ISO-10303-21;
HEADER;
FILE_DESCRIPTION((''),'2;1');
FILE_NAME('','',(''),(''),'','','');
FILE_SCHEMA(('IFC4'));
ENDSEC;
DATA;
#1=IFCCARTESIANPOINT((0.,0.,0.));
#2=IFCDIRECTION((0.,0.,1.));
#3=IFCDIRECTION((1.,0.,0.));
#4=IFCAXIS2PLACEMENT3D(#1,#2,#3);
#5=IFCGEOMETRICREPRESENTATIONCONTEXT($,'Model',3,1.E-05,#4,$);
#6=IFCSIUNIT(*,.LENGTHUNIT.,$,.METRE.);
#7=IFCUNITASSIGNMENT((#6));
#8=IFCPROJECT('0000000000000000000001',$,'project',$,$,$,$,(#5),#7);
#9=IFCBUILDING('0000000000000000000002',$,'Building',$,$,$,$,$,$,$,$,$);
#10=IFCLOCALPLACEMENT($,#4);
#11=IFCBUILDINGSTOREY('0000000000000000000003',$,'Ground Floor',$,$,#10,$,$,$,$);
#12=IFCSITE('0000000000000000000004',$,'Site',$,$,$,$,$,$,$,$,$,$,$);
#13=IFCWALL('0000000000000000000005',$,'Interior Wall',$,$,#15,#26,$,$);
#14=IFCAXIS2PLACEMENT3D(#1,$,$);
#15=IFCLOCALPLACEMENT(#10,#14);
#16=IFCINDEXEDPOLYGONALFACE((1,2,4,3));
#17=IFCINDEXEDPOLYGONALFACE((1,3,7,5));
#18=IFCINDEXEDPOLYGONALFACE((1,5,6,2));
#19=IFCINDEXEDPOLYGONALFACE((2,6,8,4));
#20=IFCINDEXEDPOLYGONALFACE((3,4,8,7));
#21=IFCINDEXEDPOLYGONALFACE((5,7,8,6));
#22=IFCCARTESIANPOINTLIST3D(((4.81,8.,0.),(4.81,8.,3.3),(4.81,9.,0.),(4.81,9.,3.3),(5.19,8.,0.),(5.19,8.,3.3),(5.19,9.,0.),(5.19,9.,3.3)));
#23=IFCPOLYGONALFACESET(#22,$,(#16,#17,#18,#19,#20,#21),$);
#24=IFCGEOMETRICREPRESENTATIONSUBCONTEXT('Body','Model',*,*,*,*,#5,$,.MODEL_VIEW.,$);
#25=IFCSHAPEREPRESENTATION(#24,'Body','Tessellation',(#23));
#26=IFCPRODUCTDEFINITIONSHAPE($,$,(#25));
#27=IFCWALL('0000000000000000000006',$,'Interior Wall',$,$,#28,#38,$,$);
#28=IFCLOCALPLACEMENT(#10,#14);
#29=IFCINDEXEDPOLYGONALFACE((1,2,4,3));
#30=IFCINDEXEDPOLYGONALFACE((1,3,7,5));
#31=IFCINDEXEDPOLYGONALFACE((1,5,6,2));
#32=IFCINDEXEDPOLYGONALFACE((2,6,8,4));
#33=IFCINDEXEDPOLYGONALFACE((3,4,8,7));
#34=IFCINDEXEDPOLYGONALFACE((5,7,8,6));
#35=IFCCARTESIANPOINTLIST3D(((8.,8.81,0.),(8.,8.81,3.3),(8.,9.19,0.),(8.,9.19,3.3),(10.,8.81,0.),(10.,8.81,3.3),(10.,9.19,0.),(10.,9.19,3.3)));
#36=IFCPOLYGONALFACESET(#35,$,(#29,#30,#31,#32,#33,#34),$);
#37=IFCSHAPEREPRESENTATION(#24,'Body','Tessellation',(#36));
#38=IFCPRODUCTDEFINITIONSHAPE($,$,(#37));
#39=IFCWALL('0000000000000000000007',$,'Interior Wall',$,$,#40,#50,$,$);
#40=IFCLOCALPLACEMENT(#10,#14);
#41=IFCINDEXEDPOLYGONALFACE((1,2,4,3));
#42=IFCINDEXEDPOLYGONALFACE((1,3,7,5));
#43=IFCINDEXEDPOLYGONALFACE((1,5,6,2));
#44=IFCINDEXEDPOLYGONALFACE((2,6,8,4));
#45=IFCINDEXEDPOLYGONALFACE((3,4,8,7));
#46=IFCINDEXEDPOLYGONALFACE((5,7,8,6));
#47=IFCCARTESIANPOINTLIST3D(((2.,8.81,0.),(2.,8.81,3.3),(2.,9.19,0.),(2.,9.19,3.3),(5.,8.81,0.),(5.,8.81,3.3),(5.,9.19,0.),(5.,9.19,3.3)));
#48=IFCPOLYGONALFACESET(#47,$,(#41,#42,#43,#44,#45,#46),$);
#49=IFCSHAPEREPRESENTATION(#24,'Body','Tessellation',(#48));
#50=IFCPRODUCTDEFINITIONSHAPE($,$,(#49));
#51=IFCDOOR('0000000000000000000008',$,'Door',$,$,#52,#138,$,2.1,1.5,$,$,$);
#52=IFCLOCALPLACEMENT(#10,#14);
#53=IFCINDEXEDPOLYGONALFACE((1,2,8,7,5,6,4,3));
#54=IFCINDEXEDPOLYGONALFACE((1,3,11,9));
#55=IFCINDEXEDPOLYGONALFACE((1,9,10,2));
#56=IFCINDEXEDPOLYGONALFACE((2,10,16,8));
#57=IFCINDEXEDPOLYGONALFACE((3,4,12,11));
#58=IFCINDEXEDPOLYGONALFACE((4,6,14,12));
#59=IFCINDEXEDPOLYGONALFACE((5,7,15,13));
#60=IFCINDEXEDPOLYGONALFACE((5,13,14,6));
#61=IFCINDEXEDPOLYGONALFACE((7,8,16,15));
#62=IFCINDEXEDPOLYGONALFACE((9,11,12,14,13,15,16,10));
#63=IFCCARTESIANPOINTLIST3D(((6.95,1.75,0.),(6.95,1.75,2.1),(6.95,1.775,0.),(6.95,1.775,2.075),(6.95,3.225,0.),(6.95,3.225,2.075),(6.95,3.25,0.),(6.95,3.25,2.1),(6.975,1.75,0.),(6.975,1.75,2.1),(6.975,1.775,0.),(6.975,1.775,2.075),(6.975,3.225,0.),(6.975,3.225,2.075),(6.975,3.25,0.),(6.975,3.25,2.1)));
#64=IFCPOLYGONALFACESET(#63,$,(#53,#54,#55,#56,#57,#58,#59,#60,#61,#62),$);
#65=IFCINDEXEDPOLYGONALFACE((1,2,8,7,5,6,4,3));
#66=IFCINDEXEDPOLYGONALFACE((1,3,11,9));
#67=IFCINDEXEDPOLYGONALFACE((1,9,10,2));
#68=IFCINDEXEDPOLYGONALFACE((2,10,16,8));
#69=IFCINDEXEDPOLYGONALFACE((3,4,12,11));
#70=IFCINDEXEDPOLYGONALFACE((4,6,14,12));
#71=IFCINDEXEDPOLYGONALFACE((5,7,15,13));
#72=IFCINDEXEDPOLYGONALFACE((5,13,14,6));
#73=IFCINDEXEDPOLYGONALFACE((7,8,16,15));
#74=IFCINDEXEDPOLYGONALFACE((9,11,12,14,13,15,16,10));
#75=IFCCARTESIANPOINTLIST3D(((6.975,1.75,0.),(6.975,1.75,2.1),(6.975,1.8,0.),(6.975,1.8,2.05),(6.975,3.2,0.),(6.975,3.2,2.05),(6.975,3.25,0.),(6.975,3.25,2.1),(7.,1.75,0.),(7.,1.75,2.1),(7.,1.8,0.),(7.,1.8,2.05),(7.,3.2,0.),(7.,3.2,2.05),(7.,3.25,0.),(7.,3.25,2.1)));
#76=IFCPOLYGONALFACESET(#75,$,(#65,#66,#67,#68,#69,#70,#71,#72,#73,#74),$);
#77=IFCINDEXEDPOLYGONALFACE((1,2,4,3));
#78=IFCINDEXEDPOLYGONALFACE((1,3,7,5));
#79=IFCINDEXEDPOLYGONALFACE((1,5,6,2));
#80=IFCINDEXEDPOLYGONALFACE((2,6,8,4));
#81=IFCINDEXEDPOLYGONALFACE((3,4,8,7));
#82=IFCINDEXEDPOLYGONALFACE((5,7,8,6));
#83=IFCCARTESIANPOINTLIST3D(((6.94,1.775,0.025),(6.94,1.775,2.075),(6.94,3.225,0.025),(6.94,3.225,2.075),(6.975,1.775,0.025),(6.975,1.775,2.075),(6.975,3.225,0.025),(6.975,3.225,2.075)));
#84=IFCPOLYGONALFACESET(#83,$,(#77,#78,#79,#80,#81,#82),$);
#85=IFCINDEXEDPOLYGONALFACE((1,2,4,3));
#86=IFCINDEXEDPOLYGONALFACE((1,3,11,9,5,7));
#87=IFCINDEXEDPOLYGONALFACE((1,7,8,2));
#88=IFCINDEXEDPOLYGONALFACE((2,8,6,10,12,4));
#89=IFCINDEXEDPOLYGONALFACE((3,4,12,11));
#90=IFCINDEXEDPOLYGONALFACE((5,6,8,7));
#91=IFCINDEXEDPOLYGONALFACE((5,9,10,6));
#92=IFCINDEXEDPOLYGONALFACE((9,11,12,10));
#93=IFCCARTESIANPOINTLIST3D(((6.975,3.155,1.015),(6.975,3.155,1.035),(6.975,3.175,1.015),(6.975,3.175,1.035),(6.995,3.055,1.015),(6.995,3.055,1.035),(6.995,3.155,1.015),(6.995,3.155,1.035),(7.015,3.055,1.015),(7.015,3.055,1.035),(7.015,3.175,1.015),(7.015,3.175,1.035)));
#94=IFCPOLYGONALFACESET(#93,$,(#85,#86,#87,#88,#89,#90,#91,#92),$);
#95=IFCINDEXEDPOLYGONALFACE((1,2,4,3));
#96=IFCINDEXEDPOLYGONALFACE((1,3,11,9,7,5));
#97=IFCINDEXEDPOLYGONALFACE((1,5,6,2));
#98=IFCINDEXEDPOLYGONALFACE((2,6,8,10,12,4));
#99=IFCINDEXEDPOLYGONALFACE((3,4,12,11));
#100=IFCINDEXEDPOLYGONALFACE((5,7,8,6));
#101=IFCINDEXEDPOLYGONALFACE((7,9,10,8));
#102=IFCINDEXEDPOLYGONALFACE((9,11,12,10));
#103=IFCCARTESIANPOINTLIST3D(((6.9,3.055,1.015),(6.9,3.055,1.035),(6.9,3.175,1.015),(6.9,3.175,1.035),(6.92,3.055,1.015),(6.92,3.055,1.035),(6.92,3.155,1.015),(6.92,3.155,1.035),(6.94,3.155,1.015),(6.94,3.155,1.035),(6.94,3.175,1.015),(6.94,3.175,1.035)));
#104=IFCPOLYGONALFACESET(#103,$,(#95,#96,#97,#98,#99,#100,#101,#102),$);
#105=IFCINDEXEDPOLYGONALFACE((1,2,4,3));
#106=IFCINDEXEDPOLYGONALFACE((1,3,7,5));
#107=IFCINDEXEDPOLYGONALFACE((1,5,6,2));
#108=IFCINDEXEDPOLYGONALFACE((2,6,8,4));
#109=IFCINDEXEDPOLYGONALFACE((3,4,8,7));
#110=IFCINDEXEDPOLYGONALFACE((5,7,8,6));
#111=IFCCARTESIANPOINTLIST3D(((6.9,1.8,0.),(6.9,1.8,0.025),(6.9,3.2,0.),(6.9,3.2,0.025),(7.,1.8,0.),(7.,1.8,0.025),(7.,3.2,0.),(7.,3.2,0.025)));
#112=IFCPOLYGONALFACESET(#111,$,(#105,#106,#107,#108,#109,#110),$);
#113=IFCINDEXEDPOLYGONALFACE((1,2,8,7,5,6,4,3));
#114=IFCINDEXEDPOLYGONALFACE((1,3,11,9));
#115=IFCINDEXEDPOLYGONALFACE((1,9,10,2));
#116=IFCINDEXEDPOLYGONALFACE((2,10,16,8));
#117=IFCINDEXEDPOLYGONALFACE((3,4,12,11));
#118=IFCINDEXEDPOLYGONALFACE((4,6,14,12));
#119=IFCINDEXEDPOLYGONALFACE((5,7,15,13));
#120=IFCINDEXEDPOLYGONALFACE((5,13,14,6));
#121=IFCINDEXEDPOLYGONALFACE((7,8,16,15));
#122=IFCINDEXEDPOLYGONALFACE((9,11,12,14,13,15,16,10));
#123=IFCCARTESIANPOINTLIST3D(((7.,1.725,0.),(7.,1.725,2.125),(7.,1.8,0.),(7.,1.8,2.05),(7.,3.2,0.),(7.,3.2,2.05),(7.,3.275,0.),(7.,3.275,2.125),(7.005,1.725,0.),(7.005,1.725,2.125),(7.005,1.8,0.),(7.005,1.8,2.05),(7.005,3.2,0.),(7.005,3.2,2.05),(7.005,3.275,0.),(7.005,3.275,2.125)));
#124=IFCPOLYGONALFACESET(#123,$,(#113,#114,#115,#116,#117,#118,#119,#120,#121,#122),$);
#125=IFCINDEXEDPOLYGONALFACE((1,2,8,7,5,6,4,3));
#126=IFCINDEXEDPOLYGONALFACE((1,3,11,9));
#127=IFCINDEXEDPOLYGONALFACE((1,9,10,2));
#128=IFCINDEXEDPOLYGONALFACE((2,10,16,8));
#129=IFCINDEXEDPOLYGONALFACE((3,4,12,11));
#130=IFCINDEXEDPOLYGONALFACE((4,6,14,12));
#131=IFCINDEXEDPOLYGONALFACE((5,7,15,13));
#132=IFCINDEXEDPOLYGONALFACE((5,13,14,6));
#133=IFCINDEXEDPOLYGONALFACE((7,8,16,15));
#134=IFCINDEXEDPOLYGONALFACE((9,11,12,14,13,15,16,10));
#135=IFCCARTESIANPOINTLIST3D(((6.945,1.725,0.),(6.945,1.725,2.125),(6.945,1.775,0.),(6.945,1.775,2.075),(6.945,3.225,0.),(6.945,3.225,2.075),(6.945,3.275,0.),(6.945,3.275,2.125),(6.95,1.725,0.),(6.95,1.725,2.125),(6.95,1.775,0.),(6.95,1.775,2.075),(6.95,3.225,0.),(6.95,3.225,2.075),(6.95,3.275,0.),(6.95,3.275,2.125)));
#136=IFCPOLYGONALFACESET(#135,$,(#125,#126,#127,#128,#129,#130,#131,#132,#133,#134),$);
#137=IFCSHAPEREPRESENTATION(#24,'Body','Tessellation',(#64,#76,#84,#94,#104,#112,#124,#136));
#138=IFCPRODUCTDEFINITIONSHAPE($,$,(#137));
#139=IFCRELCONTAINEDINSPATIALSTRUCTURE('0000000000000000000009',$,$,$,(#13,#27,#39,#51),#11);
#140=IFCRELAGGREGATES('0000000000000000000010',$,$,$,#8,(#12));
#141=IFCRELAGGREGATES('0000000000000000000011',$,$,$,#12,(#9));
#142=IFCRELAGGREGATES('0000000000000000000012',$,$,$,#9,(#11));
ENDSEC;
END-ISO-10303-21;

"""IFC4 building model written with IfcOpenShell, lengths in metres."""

from ifc_helpers import new_model, si_unit, frame, origin_with_axes, place, context, subcontext, project, spatial, line, indexed_curve, outline, extrude, element, save


model = new_model("IFC4")

# Units and contexts
model_context = context("Model", 3, precision=1e-05, world=origin_with_axes())
body_context = subcontext(model_context, "Body", "Model", "MODEL_VIEW")
ifc_project = project(units=[si_unit("LENGTHUNIT", "METRE")], contexts=[model_context])

# Site, building, storey
site = spatial("IfcSite", under=ifc_project, Name="Site")
building = spatial("IfcBuilding", under=site, Name="Building")
storey_placement = place(None, origin_with_axes())
storey = spatial("IfcBuildingStorey", under=building, at=storey_placement, Name="Ground Floor")

# Walls
wall_1_placement = place(storey_placement, frame((5.0, 9.0, 0.0), z_axis=(0.0, 0.0, 1.0), x_axis=(0.0, -1.0, 0.0)))
element("IfcWall", 1, at=wall_1_placement, inside=storey, Name="Interior Wall", context=body_context, shape_type="SweptSolid", body=[
    extrude(outline(indexed_curve([(0.0, 0.0), (0.0, 0.38), (1.0, 0.38), (1.0, 0.0), (0.0, 0.0)], self_intersect=False)), frame((0.0, -0.19, 0.0), z_axis=(0.0, 0.0, 1.0), x_axis=(1.0, 0.0, 0.0)), (0.0, 0.0, 1.0), 3.3),
])
wall_2_placement = place(storey_placement, frame((10.0, 9.0, 0.0), z_axis=(0.0, 0.0, 1.0), x_axis=(-1.0, 0.0, 0.0)))
element("IfcWall", 2, at=wall_2_placement, inside=storey, Name="Interior Wall", context=body_context, shape_type="SweptSolid", body=[
    extrude(outline(indexed_curve([(0.0, 0.0), (0.0, 0.38), (2.0, 0.38), (2.0, 0.0), (0.0, 0.0)], self_intersect=False)), frame((0.0, -0.19, 0.0), z_axis=(0.0, 0.0, 1.0), x_axis=(1.0, 0.0, 0.0)), (0.0, 0.0, 1.0), 3.3),
])
wall_3_placement = place(storey_placement, frame((5.0, 9.0, 0.0), z_axis=(0.0, 0.0, 1.0), x_axis=(-1.0, 0.0, 0.0)))
element("IfcWall", 3, at=wall_3_placement, inside=storey, Name="Interior Wall", context=body_context, shape_type="SweptSolid", body=[
    extrude(outline(indexed_curve([(0.0, 0.0), (0.0, 0.38), (3.0, 0.38), (3.0, 0.0), (0.0, 0.0)], self_intersect=False)), frame((0.0, -0.19, 0.0), z_axis=(0.0, 0.0, 1.0), x_axis=(1.0, 0.0, 0.0)), (0.0, 0.0, 1.0), 3.3),
])

# Door
door_1_placement = place(storey_placement, frame((7.0, 1.75, 0.0), z_axis=(0.0, 0.0, 1.0), x_axis=(0.0, 1.0, 0.0)))
element("IfcDoor", 4, at=door_1_placement, inside=storey, Name="Door", OverallHeight=2.1, OverallWidth=1.5, context=body_context, shape_type="SweptSolid", body=[
    extrude(outline(indexed_curve([(0.0, 0.0), (0.0, 2.1), (1.5, 2.1), (1.5, 0.0), (1.475, 0.0), (1.475, 2.075), (0.025, 2.075), (0.025, 0.0)], segments=[line(1, 2, 3, 4, 5, 6, 7, 8, 1)])), frame((0.0, 0.025, 0.0), z_axis=(0.0, -1.0, 0.0), x_axis=(1.0, 0.0, 0.0)), (0.0, 0.0, -1.0), 0.025),
    extrude(outline(indexed_curve([(0.0, 0.0), (0.0, 2.1), (1.5, 2.1), (1.5, 0.0), (1.45, 0.0), (1.45, 2.05), (0.05, 2.05), (0.05, 0.0)], segments=[line(1, 2, 3, 4, 5, 6, 7, 8, 1)])), frame((0.0, 0.0, 0.0), z_axis=(0.0, -1.0, 0.0), x_axis=(1.0, 0.0, 0.0)), (0.0, 0.0, -1.0), 0.025),
    extrude(outline(indexed_curve([(0.0, 0.0), (1.45, 0.0), (1.45, 0.035), (0.0, 0.035)], segments=[line(1, 2, 3, 4, 1)])), frame((0.025, 0.025, 0.025), z_axis=(0.0, 0.0, 1.0), x_axis=(1.0, 0.0, 0.0)), (0.0, 0.0, 1.0), 2.05),
    extrude(outline(indexed_curve([(0.0, 0.0), (0.0, -0.04), (-0.12, -0.04), (-0.12, -0.02), (-0.02, -0.02), (-0.02, 0.0)], segments=[line(1, 2, 3, 4, 5, 6, 1)])), frame((1.425, 0.025, 1.015), z_axis=(0.0, 0.0, 1.0), x_axis=(1.0, 0.0, 0.0)), (0.0, 0.0, 1.0), 0.02),
    extrude(outline(indexed_curve([(0.0, 0.0), (0.0, 0.04), (-0.12, 0.04), (-0.12, 0.02), (-0.02, 0.02), (-0.02, 0.0)], segments=[line(1, 2, 3, 4, 5, 6, 1)])), frame((1.425, 0.06, 1.015), z_axis=(0.0, 0.0, 1.0), x_axis=(1.0, 0.0, 0.0)), (0.0, 0.0, 1.0), 0.02),
    extrude(outline(indexed_curve([(0.0, 0.0), (1.4, 0.0), (1.4, 0.1), (0.0, 0.1)], segments=[line(1, 2, 3, 4, 1)])), frame((0.05, 0.0, 0.0), z_axis=(0.0, 0.0, 1.0), x_axis=(1.0, 0.0, 0.0)), (0.0, 0.0, 1.0), 0.025),
    extrude(outline(indexed_curve([(0.0, 0.0), (0.0, 2.125), (1.55, 2.125), (1.55, 0.0), (1.475, 0.0), (1.475, 2.05), (0.075, 2.05), (0.075, 0.0)], segments=[line(1, 2, 3, 4, 5, 6, 7, 8, 1)])), frame((-0.025, -0.005, 0.0), z_axis=(0.0, -1.0, 0.0), x_axis=(1.0, 0.0, 0.0)), (0.0, 0.0, -1.0), 0.005),
    extrude(outline(indexed_curve([(0.0, 0.0), (0.0, 2.125), (1.55, 2.125), (1.55, 0.0), (1.5, 0.0), (1.5, 2.075), (0.05, 2.075), (0.05, 0.0)], segments=[line(1, 2, 3, 4, 5, 6, 7, 8, 1)])), frame((-0.025, 0.05, 0.0), z_axis=(0.0, -1.0, 0.0), x_axis=(1.0, 0.0, 0.0)), (0.0, 0.0, -1.0), 0.005),
])

save(model, "model.ifc")
